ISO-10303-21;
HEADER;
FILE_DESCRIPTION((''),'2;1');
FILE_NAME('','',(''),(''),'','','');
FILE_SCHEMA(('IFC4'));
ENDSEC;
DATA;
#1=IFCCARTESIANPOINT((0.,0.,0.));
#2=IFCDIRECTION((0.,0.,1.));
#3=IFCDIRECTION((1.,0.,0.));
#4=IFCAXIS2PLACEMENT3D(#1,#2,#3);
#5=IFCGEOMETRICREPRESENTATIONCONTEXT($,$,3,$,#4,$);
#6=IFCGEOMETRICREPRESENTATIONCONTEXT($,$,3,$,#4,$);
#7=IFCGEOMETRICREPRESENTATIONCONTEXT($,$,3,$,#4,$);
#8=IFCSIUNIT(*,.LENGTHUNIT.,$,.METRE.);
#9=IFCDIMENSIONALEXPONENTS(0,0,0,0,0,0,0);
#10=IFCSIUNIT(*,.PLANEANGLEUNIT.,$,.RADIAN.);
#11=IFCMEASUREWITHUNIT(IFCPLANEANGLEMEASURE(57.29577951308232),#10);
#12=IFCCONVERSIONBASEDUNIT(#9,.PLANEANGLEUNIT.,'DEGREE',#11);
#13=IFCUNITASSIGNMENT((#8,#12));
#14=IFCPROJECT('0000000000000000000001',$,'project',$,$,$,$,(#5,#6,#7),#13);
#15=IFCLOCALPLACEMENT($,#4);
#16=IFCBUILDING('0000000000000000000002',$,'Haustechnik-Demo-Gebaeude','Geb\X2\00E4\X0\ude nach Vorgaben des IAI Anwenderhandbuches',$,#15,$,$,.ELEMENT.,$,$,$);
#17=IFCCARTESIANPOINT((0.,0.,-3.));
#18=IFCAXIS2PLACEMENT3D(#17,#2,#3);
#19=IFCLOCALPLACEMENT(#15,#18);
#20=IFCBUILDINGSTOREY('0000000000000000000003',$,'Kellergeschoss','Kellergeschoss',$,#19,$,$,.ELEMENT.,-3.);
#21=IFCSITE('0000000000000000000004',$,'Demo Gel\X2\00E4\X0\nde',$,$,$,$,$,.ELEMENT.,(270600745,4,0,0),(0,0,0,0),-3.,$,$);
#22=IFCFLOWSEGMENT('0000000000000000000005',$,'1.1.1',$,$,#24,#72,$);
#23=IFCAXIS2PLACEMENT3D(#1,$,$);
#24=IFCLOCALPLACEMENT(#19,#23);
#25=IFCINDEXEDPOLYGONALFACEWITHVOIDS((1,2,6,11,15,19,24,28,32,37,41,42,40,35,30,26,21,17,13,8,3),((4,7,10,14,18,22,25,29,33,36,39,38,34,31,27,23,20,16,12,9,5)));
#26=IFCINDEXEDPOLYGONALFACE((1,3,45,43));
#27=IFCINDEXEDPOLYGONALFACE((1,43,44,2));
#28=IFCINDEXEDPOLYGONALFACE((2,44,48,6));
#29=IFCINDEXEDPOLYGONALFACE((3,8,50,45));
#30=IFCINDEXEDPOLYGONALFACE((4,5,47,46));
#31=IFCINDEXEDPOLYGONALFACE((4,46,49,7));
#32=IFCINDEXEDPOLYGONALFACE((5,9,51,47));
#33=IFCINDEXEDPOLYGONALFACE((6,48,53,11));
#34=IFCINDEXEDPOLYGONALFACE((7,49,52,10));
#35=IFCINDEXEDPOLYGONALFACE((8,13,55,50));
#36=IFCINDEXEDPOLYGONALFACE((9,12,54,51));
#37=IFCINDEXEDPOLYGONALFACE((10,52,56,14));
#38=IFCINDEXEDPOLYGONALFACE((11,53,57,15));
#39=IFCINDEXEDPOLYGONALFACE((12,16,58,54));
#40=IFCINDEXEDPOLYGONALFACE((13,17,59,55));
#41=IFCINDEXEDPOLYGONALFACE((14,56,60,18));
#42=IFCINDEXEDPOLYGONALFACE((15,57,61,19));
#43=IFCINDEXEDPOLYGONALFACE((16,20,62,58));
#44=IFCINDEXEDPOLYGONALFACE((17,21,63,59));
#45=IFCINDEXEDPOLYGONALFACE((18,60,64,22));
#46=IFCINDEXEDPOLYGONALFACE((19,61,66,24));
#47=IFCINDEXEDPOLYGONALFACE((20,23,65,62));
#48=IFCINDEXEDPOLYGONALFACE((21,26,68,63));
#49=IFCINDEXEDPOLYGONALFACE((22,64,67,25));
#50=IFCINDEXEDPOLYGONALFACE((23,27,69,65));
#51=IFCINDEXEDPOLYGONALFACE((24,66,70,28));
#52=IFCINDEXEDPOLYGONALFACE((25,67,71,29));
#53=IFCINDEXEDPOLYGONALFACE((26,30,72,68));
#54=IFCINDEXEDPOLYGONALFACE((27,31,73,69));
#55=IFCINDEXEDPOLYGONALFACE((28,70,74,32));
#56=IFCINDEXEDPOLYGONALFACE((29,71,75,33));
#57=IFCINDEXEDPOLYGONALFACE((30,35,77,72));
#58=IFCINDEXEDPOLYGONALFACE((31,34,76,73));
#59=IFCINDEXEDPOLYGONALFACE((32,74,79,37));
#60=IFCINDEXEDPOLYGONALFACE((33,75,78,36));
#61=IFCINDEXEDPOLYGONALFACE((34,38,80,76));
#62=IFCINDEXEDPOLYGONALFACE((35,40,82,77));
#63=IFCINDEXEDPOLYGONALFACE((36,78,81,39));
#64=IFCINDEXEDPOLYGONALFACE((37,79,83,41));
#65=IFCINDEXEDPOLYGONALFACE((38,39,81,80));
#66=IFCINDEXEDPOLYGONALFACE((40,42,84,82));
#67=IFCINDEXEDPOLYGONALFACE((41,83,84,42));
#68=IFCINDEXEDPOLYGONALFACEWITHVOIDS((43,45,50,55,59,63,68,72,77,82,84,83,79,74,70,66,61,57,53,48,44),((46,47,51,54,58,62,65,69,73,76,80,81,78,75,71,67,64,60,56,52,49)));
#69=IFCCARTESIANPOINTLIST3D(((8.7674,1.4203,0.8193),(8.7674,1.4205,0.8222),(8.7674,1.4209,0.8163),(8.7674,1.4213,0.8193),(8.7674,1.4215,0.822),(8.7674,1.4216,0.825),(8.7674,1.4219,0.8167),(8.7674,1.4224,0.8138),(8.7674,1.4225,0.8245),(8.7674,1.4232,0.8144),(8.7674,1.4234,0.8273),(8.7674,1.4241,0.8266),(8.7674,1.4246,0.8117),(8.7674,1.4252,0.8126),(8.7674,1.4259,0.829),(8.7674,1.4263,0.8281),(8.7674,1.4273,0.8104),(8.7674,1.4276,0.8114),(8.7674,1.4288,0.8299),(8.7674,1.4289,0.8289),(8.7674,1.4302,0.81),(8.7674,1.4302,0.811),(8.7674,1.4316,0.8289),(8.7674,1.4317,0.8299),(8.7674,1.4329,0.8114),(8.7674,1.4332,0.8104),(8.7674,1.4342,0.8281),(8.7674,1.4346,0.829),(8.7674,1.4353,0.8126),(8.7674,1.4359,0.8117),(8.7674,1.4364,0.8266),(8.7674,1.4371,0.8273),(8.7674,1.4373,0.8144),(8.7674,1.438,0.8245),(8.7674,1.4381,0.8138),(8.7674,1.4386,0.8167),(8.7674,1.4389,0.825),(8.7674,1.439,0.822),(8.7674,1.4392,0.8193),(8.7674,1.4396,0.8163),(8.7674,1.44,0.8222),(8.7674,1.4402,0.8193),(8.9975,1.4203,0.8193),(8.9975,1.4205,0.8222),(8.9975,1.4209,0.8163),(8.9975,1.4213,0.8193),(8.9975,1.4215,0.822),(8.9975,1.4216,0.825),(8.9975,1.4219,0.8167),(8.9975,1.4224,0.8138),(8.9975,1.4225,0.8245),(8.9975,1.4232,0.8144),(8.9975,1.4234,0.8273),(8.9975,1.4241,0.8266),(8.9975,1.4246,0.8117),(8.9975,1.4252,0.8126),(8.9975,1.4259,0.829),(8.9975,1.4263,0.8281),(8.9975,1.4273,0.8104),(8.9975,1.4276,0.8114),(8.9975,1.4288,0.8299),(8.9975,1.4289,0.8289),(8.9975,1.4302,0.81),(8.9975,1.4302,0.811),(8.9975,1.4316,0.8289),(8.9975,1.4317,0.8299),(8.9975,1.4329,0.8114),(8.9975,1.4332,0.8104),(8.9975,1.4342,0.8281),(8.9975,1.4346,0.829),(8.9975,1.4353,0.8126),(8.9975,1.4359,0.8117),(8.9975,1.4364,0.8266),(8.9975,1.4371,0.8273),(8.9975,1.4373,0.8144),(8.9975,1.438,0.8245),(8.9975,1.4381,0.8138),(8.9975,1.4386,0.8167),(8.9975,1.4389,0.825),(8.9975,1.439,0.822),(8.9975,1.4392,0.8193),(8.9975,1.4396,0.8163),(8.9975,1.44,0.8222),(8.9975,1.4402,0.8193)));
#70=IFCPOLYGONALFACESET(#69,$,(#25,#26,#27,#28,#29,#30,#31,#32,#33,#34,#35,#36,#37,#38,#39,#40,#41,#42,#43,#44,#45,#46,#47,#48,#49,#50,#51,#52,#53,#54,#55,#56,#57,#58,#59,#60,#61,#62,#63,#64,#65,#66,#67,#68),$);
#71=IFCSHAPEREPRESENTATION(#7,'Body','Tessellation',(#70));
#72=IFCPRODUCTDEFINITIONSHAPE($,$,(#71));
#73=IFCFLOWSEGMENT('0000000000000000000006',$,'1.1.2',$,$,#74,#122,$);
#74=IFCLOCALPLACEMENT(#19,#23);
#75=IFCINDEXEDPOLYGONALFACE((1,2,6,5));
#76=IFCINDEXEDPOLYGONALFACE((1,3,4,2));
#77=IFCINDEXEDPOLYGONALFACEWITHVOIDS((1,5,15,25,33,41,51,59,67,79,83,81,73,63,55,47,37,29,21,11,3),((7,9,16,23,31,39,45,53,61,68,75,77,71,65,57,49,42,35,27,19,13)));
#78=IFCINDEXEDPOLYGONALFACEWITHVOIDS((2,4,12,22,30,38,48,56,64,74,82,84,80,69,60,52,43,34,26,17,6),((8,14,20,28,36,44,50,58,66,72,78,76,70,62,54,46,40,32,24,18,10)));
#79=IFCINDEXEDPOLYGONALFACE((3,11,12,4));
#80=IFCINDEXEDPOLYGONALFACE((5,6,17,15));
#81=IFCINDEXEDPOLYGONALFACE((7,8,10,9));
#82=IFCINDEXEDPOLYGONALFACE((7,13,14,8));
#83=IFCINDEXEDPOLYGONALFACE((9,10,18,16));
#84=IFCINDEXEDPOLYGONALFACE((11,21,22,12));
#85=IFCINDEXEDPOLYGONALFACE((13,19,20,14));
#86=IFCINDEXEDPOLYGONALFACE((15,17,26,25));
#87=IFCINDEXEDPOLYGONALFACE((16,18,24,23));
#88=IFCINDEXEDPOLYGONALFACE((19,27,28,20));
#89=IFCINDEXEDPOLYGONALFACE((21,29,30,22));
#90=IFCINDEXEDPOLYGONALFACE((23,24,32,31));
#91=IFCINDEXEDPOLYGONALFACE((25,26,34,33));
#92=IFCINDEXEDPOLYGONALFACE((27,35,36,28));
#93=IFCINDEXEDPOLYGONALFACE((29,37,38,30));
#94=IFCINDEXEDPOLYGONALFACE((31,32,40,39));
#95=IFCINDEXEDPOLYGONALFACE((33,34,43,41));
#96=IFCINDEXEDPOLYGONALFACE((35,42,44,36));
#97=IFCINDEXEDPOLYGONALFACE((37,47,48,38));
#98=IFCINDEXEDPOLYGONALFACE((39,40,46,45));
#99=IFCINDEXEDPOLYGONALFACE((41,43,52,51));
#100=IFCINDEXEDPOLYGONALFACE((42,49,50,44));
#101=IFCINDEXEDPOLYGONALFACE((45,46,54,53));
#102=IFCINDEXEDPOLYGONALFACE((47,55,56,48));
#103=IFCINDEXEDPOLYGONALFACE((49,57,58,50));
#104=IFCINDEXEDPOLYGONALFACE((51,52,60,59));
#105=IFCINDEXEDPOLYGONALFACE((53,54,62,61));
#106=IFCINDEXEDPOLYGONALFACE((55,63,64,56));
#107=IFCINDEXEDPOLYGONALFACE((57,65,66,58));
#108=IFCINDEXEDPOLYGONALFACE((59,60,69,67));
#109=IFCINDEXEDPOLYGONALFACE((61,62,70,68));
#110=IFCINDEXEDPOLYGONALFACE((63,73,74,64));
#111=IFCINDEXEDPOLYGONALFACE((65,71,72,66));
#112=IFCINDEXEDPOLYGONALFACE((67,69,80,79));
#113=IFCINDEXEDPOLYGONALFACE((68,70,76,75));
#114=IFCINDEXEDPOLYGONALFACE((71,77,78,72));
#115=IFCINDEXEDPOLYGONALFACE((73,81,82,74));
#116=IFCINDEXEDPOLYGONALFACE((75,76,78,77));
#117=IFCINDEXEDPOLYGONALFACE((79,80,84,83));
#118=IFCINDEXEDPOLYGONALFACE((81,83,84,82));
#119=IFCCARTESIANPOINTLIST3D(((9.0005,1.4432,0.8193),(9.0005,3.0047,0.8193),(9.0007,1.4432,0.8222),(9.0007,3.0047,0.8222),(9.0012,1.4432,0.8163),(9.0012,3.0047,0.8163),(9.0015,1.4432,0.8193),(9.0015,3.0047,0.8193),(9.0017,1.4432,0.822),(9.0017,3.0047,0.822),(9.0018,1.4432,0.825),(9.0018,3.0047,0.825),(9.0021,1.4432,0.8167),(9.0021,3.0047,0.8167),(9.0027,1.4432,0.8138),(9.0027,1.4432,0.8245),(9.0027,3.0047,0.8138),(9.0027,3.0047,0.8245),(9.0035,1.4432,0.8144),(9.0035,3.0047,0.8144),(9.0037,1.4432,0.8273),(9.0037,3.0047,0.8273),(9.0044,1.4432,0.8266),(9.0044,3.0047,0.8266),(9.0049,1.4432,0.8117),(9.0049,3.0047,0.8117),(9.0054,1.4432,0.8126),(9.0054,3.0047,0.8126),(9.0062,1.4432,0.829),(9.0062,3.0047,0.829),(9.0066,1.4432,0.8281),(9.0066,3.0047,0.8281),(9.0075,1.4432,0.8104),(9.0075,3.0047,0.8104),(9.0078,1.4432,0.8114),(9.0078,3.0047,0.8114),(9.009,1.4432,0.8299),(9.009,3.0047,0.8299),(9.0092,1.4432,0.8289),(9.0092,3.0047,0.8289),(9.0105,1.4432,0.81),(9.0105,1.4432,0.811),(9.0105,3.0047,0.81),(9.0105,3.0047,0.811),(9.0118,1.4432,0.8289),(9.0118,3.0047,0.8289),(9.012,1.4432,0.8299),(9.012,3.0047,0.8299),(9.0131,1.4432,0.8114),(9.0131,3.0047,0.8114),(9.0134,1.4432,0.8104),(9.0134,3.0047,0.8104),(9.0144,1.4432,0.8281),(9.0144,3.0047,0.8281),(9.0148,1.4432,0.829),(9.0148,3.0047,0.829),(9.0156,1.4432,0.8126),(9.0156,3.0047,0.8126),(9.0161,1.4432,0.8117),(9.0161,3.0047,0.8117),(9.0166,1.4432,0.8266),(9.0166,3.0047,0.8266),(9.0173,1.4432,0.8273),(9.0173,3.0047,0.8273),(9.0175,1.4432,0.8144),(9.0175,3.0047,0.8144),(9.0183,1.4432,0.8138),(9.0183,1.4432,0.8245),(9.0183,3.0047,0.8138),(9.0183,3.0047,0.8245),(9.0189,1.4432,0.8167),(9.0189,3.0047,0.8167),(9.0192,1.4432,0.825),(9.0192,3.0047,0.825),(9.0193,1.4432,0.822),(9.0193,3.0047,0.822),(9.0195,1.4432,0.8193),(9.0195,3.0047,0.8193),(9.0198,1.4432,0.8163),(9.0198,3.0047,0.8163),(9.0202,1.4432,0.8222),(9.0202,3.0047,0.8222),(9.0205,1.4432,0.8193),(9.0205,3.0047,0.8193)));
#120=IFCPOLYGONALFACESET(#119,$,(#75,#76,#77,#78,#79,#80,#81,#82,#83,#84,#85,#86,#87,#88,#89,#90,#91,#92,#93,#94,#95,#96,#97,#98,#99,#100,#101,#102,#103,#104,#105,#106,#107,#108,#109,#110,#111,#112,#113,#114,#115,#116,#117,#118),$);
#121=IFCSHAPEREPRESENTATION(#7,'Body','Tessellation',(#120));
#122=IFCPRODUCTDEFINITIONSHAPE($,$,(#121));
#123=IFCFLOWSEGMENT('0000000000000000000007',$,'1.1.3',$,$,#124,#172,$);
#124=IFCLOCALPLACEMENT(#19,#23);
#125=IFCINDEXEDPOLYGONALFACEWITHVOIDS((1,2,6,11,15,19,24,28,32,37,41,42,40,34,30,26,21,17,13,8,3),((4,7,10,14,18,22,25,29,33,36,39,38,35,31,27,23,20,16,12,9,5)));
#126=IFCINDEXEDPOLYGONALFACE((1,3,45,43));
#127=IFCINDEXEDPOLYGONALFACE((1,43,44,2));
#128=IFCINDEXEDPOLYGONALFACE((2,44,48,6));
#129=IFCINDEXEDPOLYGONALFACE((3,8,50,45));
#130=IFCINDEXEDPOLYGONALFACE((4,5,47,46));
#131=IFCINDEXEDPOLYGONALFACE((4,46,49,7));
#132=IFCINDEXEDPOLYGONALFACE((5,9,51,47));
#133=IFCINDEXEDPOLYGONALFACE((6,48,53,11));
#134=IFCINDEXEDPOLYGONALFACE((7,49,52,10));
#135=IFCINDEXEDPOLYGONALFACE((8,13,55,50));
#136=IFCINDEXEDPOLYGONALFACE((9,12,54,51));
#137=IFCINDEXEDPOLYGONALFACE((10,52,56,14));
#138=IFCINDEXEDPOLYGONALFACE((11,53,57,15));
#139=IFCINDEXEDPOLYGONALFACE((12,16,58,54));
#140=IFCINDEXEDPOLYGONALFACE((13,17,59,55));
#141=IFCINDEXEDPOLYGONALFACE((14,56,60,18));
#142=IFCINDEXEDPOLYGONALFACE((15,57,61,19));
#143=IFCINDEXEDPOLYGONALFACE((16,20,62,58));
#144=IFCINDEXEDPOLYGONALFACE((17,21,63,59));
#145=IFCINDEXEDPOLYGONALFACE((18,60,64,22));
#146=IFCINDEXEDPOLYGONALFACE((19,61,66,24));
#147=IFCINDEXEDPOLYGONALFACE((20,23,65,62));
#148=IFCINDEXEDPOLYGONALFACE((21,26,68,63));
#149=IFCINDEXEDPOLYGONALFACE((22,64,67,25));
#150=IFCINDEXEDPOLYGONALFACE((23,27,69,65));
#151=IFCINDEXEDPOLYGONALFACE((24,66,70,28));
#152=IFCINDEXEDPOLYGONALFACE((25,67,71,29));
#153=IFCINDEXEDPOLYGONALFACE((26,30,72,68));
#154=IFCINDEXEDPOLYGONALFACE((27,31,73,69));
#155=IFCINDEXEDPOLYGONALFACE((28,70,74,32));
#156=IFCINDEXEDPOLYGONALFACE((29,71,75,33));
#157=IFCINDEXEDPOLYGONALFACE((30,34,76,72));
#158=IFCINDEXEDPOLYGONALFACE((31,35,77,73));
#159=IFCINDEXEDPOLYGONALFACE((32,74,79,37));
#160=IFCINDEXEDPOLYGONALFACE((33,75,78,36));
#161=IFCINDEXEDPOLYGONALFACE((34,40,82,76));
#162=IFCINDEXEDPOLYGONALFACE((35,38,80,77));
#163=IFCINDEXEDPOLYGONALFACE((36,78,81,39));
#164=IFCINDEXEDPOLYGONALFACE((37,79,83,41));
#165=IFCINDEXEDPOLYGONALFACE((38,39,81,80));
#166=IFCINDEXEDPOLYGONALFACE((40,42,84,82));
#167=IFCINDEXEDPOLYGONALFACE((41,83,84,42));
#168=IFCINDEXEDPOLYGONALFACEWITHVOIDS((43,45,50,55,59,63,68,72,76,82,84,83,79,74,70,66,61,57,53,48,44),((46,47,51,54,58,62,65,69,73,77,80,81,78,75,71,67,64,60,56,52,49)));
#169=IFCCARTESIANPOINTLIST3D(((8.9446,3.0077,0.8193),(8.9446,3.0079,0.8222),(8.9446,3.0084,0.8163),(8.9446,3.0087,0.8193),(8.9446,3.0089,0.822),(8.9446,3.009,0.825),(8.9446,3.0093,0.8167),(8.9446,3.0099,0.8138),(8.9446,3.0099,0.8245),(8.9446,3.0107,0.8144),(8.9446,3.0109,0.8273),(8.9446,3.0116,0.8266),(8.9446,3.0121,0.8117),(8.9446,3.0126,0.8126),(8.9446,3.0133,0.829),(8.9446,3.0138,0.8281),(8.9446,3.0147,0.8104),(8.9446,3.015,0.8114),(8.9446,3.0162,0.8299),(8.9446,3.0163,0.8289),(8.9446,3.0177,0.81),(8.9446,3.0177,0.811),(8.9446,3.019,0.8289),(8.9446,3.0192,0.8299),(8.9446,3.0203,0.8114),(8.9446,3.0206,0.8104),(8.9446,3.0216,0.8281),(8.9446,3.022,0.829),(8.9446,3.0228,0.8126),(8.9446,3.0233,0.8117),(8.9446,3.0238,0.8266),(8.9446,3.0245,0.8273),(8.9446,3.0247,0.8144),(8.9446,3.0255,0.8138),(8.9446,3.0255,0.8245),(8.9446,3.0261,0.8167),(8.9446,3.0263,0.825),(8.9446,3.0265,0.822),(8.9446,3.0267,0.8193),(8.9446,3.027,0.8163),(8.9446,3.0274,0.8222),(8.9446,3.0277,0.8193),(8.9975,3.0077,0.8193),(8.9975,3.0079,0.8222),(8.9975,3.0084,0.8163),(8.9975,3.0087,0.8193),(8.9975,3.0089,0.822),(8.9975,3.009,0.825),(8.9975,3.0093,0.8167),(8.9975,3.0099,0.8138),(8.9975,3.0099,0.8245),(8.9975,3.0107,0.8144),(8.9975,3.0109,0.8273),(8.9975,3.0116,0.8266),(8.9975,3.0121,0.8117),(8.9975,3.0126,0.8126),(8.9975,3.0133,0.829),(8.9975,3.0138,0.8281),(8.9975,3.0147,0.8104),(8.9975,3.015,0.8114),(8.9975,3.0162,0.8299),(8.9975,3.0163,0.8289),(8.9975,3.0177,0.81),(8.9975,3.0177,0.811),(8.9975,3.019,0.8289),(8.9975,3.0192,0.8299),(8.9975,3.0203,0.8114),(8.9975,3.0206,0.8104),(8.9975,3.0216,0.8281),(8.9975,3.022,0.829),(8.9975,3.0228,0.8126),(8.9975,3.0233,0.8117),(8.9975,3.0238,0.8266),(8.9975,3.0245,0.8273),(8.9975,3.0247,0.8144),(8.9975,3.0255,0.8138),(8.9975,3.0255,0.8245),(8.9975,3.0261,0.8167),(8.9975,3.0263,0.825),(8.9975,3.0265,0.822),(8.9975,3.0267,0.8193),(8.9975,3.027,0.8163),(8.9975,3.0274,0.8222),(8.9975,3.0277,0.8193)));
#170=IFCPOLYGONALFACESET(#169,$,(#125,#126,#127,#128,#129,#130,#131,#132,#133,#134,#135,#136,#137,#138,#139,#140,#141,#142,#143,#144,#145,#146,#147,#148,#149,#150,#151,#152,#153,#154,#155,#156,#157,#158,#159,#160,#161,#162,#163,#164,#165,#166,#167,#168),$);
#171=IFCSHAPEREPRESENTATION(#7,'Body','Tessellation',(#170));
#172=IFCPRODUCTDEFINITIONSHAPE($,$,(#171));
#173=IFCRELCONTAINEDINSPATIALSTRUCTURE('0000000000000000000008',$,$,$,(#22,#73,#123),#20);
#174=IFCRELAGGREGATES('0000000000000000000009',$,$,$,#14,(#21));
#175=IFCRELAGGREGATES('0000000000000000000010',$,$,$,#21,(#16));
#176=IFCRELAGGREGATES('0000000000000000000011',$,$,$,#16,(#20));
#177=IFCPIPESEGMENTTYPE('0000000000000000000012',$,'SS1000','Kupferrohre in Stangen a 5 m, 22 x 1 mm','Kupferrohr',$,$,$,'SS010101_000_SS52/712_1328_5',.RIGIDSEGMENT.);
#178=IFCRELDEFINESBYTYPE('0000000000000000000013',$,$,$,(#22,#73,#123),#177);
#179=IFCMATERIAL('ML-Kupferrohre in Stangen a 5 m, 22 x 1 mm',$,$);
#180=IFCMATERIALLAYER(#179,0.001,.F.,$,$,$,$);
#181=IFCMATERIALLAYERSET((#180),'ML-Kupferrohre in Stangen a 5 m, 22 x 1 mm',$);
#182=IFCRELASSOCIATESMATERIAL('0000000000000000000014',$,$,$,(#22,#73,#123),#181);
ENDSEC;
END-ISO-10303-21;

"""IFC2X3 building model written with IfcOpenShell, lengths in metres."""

from ifc_helpers import new_model, entity, si_unit, converted_unit, frame, origin_with_axes, origin_2d_with_axis, place, context, project, spatial, hollow_circle, extrude, material, layer, layer_set, layer_usage, type_object, element, save


model = new_model("IFC2X3")

# Units and contexts
context_of_model_1 = context(None, 3, world=origin_with_axes())
context_of_model_2 = context(None, 3, world=origin_with_axes())
context_of_model_3 = context(None, 3, world=origin_with_axes())
ifc_project = project(units=[si_unit("LENGTHUNIT", "METRE"), converted_unit("PLANEANGLEUNIT", "DEGREE", entity("IfcPlaneAngleMeasure", 57.29577951308232), si_unit("PLANEANGLEUNIT", "RADIAN"), dimensions=[0, 0, 0, 0, 0, 0, 0])], contexts=[context_of_model_1, context_of_model_2, context_of_model_3])

# Site, building, storey
site = spatial("IfcSite", under=ifc_project, Name="Demo Gelände", CompositionType="ELEMENT", RefLatitude=(270600745, 4, 0, 0), RefLongitude=(0, 0, 0, 0), RefElevation=-3.0)
building_placement = place(None, origin_with_axes())
building = spatial("IfcBuilding", under=site, at=building_placement, Name="Haustechnik-Demo-Gebaeude", Description="Gebäude nach Vorgaben des IAI Anwenderhandbuches", CompositionType="ELEMENT")
storey_placement = place(building_placement, frame((0.0, 0.0, -3.0), z_axis=(0.0, 0.0, 1.0), x_axis=(1.0, 0.0, 0.0)))
storey = spatial("IfcBuildingStorey", under=building, at=storey_placement, Name="Kellergeschoss", Description="Kellergeschoss", CompositionType="ELEMENT", Elevation=-3.0)

# Flow segments
ifc_material = material(Name="ML-Kupferrohre in Stangen a 5 m, 22 x 1 mm")
ifc_layer = layer(ifc_material, 0.001, ventilated=False)
ifc_layer_set = layer_set([ifc_layer], Name="ML-Kupferrohre in Stangen a 5 m, 22 x 1 mm")
ifc_layer_usage = layer_usage(ifc_layer_set, "AXIS2", "POSITIVE", 0.0)
pipe_segment_type_1 = type_object("IfcPipeSegmentType", Name="SS1000", Description="Kupferrohre in Stangen a 5 m, 22 x 1 mm", ApplicableOccurrence="Kupferrohr", ElementType="SS010101_000_SS52/712_1328_5", PredefinedType="RIGIDSEGMENT")
flow_segment_1_placement = place(storey_placement, frame((8.7674, 1.4302, 0.82), z_axis=(1.0, 0.0, 0.0), x_axis=(0.0, 0.0, -1.0)))
element("IfcFlowSegment", 1, at=flow_segment_1_placement, inside=storey, type_object=pipe_segment_type_1, material=ifc_layer_usage, Name="1.1.1", context=context_of_model_3, shape_type="SweptSolid", body=[
    extrude(hollow_circle(Radius=0.01, WallThickness=0.001, at=origin_2d_with_axis()), origin_with_axes(), (0.0, 0.0, 1.0), 0.2301),
])
flow_segment_2_placement = place(storey_placement, frame((9.0105, 1.4432, 0.82), z_axis=(0.0, 1.0, 0.0), x_axis=(0.0, 0.0, -1.0)))
element("IfcFlowSegment", 2, at=flow_segment_2_placement, inside=storey, type_object=pipe_segment_type_1, material=ifc_layer_usage, Name="1.1.2", context=context_of_model_3, shape_type="SweptSolid", body=[
    extrude(hollow_circle(Radius=0.01, WallThickness=0.001, at=origin_2d_with_axis()), origin_with_axes(), (0.0, 0.0, 1.0), 1.5614),
])
flow_segment_3_placement = place(storey_placement, frame((8.9975, 3.0177, 0.82), z_axis=(-1.0, 0.0, 0.0), x_axis=(0.0, 0.0, -1.0)))
element("IfcFlowSegment", 3, at=flow_segment_3_placement, inside=storey, type_object=pipe_segment_type_1, material=ifc_layer_usage, Name="1.1.3", context=context_of_model_3, shape_type="SweptSolid", body=[
    extrude(hollow_circle(Radius=0.01, WallThickness=0.001, at=origin_2d_with_axis()), origin_with_axes(), (0.0, 0.0, 1.0), 0.0529),
])

save(model, "model.ifc")
